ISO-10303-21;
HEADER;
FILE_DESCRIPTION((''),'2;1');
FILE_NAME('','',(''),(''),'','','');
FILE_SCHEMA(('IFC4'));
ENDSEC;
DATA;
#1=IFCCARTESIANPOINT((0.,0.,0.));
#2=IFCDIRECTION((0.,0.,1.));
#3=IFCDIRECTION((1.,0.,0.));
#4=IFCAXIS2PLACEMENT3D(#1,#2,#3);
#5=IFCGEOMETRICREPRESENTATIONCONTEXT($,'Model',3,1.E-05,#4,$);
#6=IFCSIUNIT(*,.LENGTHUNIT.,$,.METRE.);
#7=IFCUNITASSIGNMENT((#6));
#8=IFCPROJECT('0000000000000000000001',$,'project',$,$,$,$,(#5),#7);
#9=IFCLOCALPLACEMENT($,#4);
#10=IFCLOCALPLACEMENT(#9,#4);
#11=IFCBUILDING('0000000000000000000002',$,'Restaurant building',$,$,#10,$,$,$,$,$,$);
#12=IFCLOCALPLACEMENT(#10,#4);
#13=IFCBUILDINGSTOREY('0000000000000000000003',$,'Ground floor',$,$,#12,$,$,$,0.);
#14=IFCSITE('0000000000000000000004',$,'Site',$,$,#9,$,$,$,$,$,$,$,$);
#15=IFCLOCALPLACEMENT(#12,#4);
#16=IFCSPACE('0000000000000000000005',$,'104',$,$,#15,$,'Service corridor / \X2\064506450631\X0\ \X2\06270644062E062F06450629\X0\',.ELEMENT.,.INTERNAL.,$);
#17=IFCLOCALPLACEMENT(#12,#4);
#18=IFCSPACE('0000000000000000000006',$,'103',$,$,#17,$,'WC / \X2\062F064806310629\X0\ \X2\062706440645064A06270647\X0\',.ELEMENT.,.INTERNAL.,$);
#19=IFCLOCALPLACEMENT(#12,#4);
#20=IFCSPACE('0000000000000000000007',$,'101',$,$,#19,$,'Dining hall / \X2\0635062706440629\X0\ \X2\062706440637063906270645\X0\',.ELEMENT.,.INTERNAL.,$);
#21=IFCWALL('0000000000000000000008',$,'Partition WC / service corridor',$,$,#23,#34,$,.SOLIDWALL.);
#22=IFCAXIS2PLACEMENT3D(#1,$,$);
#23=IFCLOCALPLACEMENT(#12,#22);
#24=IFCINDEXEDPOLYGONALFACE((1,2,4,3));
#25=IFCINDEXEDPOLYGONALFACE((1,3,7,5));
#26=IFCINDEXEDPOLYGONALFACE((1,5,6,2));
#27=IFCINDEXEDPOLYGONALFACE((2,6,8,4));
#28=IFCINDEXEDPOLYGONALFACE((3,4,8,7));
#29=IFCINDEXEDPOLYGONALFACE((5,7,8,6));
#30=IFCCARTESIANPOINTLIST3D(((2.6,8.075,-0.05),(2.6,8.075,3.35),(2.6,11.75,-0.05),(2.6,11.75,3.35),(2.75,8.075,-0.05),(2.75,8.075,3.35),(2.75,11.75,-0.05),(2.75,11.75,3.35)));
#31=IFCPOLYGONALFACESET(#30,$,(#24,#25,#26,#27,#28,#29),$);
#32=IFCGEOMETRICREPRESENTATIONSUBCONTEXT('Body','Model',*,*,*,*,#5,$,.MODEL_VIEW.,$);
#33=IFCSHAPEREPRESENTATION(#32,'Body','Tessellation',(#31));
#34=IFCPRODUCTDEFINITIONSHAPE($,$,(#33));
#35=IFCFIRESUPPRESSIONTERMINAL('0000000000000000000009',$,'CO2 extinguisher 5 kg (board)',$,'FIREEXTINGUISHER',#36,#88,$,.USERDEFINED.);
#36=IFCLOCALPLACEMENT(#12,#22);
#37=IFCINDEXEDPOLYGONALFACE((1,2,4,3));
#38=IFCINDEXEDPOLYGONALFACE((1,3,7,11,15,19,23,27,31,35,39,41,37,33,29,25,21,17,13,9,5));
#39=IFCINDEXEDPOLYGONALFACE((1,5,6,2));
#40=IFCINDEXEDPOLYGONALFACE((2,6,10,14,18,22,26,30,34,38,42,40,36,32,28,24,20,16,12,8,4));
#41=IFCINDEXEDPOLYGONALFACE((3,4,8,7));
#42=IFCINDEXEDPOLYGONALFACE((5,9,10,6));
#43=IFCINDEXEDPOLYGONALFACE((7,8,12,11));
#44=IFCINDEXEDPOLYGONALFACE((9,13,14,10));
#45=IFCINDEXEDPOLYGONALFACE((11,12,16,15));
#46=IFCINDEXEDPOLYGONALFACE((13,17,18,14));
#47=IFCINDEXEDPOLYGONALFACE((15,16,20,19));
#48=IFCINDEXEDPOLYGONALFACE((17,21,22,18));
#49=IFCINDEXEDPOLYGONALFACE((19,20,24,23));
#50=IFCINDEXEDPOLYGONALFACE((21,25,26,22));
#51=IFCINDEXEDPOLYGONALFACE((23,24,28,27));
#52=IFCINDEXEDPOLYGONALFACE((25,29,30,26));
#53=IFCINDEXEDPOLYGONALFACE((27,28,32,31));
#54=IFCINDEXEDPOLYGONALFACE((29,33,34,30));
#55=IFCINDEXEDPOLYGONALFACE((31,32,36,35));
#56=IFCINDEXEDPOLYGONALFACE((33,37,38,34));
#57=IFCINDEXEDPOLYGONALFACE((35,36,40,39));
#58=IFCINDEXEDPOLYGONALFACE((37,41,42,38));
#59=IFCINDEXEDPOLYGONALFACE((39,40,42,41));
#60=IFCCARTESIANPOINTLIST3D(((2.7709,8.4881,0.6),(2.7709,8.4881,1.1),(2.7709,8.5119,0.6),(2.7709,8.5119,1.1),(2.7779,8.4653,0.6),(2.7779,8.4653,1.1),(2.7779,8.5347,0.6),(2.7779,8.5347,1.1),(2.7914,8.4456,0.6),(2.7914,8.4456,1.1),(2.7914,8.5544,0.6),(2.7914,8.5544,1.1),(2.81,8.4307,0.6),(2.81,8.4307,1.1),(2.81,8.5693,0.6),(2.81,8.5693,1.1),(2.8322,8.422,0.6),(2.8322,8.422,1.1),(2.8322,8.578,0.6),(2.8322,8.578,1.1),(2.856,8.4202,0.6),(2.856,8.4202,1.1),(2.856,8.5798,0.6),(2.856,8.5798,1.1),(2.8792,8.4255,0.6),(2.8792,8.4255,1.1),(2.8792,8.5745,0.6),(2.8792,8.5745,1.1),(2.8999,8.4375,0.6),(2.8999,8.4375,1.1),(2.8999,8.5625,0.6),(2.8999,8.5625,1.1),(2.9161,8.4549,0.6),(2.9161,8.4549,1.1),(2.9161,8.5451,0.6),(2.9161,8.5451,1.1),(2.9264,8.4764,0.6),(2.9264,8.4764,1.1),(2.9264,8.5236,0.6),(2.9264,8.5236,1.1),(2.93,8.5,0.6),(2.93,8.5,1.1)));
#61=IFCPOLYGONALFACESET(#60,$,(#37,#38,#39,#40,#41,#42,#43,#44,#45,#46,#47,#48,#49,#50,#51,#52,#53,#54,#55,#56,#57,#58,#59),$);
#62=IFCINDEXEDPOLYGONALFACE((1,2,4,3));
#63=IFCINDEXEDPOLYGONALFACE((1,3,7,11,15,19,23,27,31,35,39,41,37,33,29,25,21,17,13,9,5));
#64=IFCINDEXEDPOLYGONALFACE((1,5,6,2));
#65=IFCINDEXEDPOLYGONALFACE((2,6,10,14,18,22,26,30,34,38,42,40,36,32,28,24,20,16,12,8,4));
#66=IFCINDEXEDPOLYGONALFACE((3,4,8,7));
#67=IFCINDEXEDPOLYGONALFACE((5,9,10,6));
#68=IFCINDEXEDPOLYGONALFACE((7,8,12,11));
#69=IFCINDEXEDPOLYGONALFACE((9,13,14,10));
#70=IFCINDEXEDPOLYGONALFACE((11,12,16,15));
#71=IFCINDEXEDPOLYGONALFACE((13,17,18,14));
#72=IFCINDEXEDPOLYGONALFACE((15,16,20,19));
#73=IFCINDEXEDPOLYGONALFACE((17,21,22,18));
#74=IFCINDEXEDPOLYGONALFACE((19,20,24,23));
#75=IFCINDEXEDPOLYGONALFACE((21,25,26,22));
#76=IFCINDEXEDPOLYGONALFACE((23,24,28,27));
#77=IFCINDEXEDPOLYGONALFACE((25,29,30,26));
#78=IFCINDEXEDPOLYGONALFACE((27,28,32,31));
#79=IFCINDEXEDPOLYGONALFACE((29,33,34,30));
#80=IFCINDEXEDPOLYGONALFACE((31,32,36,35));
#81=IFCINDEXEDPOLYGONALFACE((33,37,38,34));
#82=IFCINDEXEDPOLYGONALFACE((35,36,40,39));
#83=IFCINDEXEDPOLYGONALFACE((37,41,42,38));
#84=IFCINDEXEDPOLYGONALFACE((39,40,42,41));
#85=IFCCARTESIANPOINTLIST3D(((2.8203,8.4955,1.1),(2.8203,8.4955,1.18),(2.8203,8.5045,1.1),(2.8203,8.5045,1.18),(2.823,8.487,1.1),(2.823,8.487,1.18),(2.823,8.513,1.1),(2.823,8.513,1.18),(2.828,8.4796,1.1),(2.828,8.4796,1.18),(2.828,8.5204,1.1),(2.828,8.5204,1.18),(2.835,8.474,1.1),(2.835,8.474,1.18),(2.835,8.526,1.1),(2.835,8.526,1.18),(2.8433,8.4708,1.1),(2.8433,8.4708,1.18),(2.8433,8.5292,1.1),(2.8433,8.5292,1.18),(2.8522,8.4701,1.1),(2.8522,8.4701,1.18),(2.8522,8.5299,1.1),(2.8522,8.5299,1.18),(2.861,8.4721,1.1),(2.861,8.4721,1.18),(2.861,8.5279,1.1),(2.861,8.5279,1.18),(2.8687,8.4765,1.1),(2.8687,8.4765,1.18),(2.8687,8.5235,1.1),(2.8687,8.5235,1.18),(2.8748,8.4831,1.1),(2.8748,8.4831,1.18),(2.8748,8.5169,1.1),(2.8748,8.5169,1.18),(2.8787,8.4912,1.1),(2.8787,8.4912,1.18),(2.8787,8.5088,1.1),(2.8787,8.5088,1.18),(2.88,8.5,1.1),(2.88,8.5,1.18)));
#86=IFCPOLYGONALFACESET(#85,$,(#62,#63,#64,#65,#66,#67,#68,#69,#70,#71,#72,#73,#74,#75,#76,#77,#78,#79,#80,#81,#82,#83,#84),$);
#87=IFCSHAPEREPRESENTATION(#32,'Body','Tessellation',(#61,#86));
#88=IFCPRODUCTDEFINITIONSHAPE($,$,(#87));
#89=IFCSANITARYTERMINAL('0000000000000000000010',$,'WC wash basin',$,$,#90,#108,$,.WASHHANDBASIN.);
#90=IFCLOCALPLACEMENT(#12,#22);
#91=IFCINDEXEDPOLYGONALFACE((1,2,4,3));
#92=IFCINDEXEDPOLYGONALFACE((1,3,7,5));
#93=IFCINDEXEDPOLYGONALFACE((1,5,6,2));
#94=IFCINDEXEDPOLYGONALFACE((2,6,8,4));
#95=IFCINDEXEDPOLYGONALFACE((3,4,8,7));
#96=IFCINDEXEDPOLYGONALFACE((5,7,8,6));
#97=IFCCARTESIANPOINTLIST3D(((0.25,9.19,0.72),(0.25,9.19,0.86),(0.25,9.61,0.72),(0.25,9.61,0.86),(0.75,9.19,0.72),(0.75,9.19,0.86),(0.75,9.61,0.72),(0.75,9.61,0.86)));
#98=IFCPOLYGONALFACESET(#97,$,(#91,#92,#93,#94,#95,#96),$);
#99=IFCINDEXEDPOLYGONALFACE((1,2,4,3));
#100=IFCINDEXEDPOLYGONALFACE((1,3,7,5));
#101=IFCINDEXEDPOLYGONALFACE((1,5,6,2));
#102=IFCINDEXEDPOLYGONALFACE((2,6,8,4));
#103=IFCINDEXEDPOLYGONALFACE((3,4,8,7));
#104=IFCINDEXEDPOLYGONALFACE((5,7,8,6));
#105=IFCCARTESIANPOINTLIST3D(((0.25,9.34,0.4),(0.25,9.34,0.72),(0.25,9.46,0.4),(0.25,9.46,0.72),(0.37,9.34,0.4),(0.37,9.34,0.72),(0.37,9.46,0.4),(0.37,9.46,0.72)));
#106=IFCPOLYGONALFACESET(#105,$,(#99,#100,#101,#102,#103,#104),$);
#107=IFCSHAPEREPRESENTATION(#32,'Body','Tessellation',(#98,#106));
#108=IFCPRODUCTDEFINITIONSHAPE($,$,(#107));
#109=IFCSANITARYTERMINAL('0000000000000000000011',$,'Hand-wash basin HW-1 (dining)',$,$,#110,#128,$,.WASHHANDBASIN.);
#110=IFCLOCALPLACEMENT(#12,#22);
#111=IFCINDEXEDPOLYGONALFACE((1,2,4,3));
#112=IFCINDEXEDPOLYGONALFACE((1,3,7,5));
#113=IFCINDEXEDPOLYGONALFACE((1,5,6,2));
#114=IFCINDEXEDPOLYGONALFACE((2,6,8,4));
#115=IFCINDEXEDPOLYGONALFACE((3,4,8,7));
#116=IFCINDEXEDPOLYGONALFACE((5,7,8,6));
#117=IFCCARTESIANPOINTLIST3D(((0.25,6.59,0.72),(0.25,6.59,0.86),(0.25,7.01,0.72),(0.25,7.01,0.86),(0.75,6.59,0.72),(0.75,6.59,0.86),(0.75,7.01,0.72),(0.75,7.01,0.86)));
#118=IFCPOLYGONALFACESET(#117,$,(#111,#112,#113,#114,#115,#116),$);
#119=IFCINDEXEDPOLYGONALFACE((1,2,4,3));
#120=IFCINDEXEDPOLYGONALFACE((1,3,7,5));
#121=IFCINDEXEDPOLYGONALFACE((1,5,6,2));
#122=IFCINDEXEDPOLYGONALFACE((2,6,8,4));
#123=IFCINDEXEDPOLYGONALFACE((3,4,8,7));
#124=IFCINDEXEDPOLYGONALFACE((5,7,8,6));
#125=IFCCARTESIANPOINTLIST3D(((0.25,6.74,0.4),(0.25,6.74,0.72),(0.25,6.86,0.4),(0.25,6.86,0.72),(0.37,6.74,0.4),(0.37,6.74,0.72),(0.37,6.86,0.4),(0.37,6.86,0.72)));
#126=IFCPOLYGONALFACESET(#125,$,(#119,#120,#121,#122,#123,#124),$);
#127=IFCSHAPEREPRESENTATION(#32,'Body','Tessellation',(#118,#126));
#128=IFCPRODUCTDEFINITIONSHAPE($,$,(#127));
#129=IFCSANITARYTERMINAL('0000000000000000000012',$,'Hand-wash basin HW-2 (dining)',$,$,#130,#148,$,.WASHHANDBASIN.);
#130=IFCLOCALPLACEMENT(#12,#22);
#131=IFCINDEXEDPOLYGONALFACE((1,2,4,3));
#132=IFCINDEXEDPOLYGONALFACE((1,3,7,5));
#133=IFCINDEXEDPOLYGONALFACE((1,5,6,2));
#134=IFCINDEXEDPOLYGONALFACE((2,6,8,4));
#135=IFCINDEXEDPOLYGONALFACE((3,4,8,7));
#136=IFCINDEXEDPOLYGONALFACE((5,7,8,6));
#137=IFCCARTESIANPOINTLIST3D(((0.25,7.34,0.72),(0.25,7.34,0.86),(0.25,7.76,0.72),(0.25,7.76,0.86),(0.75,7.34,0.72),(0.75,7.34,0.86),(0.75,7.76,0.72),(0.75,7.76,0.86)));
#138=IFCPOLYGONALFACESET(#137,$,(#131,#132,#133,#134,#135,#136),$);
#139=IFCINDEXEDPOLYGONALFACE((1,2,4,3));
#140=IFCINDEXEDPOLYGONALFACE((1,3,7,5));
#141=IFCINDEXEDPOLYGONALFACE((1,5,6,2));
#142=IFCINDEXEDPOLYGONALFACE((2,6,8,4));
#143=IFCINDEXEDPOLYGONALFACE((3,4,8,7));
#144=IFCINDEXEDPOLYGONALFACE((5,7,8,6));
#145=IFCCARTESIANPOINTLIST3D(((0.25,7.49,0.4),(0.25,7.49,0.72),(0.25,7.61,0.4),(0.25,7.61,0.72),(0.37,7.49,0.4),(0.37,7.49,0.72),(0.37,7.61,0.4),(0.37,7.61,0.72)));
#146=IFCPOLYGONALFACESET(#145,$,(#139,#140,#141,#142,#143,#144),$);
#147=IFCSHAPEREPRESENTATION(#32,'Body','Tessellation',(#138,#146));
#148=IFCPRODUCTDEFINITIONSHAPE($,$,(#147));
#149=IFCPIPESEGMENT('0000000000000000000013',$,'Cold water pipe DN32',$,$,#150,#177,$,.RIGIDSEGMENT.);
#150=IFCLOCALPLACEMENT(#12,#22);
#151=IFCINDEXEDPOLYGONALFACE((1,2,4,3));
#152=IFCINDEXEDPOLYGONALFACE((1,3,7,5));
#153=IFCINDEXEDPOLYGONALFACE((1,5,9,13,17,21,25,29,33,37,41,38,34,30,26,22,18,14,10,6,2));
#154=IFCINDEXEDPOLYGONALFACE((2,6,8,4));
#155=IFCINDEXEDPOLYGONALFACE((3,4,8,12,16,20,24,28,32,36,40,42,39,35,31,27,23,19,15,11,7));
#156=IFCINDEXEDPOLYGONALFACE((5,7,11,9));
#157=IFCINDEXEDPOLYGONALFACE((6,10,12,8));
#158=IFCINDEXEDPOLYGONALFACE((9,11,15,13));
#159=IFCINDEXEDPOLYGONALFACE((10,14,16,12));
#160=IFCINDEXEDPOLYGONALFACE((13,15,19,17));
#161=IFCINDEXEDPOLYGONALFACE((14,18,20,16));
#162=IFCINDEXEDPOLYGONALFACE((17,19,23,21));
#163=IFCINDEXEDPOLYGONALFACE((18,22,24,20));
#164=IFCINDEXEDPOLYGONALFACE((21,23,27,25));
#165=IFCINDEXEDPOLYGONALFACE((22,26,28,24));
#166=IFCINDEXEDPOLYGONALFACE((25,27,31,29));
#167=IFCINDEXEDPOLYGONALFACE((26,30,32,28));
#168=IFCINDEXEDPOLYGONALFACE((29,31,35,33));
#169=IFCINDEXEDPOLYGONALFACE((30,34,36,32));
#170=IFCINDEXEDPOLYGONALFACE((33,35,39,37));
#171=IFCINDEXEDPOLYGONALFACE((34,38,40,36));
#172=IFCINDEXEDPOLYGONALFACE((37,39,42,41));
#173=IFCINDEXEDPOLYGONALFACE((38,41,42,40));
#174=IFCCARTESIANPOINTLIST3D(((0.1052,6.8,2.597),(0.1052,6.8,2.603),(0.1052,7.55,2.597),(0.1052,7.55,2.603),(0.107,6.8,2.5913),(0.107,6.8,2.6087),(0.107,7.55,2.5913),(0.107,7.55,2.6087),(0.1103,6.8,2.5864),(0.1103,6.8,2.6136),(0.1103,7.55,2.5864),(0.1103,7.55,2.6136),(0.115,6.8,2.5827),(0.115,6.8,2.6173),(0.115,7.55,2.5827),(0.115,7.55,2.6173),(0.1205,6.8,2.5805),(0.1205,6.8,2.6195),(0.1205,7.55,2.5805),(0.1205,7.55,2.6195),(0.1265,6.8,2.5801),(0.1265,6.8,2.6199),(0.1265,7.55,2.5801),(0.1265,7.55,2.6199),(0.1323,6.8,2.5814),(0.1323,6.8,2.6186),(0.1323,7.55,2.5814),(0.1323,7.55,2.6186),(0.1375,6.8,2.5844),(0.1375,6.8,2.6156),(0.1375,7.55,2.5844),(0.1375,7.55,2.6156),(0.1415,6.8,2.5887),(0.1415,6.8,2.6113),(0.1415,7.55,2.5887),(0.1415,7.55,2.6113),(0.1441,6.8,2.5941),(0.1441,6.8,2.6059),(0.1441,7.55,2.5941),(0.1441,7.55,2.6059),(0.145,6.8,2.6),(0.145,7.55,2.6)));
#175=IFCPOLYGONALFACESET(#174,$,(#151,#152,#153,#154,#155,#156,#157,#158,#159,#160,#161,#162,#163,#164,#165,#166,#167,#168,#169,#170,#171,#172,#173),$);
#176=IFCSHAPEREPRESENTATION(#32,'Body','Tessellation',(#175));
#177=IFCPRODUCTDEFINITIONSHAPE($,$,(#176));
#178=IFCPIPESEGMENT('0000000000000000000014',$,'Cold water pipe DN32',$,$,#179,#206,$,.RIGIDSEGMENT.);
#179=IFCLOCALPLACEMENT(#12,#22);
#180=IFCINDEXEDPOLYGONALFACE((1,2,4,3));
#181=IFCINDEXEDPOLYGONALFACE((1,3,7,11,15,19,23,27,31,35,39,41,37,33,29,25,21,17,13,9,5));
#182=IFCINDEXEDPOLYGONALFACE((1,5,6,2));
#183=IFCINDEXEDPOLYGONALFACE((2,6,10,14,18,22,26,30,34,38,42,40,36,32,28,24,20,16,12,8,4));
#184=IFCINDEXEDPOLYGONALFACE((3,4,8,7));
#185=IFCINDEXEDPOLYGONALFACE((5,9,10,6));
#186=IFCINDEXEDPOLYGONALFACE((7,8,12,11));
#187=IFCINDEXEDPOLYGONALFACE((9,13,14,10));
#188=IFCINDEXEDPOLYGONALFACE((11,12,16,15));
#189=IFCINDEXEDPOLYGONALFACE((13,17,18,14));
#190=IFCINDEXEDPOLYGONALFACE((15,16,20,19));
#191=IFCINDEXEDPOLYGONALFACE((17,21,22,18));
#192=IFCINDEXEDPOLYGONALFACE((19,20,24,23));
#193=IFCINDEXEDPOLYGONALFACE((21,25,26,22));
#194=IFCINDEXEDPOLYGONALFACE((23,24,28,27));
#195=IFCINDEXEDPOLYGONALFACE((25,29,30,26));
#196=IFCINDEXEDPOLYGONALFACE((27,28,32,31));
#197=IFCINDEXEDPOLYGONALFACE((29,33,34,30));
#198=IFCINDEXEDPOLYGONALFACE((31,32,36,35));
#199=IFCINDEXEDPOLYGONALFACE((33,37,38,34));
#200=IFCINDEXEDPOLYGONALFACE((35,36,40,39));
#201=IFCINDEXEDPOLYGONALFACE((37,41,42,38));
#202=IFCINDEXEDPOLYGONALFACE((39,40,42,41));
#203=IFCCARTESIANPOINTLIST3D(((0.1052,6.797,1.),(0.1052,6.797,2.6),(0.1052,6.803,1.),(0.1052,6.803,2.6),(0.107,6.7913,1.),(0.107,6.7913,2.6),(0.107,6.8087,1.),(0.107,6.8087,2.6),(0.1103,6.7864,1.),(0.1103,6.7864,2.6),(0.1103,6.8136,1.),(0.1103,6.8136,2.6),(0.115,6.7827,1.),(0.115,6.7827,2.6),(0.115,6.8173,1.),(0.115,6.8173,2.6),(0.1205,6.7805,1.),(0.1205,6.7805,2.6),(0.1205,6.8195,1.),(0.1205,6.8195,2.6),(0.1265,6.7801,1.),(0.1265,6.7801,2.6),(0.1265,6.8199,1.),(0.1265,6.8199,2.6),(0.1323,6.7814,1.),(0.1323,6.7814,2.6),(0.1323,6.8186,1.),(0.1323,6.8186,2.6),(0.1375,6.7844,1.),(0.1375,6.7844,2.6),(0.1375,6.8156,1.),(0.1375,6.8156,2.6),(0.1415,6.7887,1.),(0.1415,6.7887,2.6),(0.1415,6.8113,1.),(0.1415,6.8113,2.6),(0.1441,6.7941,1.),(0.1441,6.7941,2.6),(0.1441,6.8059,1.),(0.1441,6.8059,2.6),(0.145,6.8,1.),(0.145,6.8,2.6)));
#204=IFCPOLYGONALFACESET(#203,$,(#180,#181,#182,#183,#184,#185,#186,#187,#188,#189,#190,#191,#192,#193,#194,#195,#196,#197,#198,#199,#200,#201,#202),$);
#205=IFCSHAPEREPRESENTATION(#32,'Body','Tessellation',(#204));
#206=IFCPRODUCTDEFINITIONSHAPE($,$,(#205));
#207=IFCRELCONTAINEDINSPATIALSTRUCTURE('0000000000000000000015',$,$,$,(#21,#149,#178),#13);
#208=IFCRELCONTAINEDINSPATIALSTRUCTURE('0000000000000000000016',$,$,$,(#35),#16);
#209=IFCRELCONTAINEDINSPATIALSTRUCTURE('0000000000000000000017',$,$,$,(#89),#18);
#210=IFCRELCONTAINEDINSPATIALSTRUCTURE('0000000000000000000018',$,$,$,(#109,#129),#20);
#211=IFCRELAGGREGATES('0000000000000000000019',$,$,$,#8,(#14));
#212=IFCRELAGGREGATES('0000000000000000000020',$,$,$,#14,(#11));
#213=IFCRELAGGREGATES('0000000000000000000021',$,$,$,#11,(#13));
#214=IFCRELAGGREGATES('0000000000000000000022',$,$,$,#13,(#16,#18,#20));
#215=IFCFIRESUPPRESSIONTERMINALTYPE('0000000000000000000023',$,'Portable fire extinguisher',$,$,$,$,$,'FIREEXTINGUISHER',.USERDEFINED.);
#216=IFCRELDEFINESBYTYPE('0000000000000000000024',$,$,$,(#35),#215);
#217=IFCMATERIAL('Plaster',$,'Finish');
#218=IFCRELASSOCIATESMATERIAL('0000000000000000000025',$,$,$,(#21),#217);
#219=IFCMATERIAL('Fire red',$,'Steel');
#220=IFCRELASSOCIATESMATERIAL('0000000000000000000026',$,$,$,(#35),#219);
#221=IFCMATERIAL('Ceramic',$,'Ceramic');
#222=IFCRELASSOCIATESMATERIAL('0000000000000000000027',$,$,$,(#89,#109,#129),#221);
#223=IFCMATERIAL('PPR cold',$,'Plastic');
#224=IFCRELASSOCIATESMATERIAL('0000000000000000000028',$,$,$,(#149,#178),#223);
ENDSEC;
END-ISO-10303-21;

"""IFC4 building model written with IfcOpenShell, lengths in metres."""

from ifc_helpers import new_model, si_unit, frame, origin, origin_with_axes, origin_2d, place, context, subcontext, project, spatial, rectangle, circle, extrude, source, transform, mapped, material, type_object, type_shapes, element, save


model = new_model("IFC4")

# Units and contexts
model_context = context("Model", 3, precision=1e-05, world=origin_with_axes())
body_context = subcontext(model_context, "Body", "Model", "MODEL_VIEW")
ifc_project = project(units=[si_unit("LENGTHUNIT", "METRE")], contexts=[model_context])

# Site, building, storey
site_placement = place(None, origin_with_axes())
site = spatial("IfcSite", under=ifc_project, at=site_placement, Name="Site")
building_placement = place(site_placement, origin_with_axes())
building = spatial("IfcBuilding", under=site, at=building_placement, Name="Restaurant building")
storey_placement = place(building_placement, origin_with_axes())
storey = spatial("IfcBuildingStorey", under=building, at=storey_placement, Name="Ground floor", Elevation=0.0)

# Shared definitions
ifc_material_1 = material(Name="Plaster", Category="Finish")

# Wall
wall_1_placement = place(storey_placement, frame((2.675, 8.075, 0.0), z_axis=(0.0, 0.0, 1.0), x_axis=(0.0, 1.0, 0.0)))
element("IfcWall", 1, at=wall_1_placement, inside=storey, material=ifc_material_1, Name="Partition WC / service corridor", PredefinedType="SOLIDWALL", context=body_context, shape_type="SweptSolid", body=[
    extrude(rectangle(XDim=3.675, YDim=0.15, at=origin_2d()), frame((1.8375, 0.0, -0.05)), (0.0, 0.0, 1.0), 3.4),
])

# Shared definitions
space_1_placement = place(storey_placement, origin_with_axes())
space_1 = spatial("IfcSpace", under=storey, at=space_1_placement, Name="104", LongName="Service corridor / ممر الخدمة", CompositionType="ELEMENT", PredefinedType="INTERNAL")

# Fire suppression terminal
ifc_material_2 = material(Name="Fire red", Category="Steel")
fire_suppression_terminal_type = type_object("IfcFireSuppressionTerminalType", Name="Portable fire extinguisher", ElementType="FIREEXTINGUISHER", PredefinedType="USERDEFINED")
shared_shape = source(origin(), body_context, "Body", "SweptSolid", [
    extrude(circle(Radius=0.08, at=origin_2d()), origin(), (0.0, 0.0, 1.0), 0.5),
    extrude(circle(Radius=0.03, at=origin_2d()), frame((0.0, 0.0, 0.5)), (0.0, 0.0, 1.0), 0.08),
])
type_shapes(fire_suppression_terminal_type, [shared_shape])
fire_suppression_terminal_placement = place(storey_placement, frame((2.85, 8.5, 0.6)))
element("IfcFireSuppressionTerminal", 2, at=fire_suppression_terminal_placement, inside=space_1, type_object=fire_suppression_terminal_type, material=ifc_material_2, Name="CO2 extinguisher 5 kg (board)", ObjectType="FIREEXTINGUISHER", PredefinedType="USERDEFINED", context=body_context, shape_type="MappedRepresentation", body=[
    mapped(shared_shape, transform((0.0, 0.0, 0.0))),
])

# Shared definitions
space_2_placement = place(storey_placement, origin_with_axes())
space_2 = spatial("IfcSpace", under=storey, at=space_2_placement, Name="103", LongName="WC / دورة المياه", CompositionType="ELEMENT", PredefinedType="INTERNAL")

# Sanitary terminal
ifc_material_3 = material(Name="Ceramic", Category="Ceramic")
sanitary_terminal_placement = place(storey_placement, frame((0.25, 9.4, 0.0)))
element("IfcSanitaryTerminal", 3, at=sanitary_terminal_placement, inside=space_2, material=ifc_material_3, Name="WC wash basin", PredefinedType="WASHHANDBASIN", context=body_context, shape_type="SweptSolid", body=[
    extrude(rectangle(XDim=0.5, YDim=0.42, at=origin_2d()), frame((0.25, 0.0, 0.72)), (0.0, 0.0, 1.0), 0.14),
    extrude(rectangle(XDim=0.12, YDim=0.12, at=origin_2d()), frame((0.06, 0.0, 0.4)), (0.0, 0.0, 1.0), 0.32),
])

# Shared definitions
space_3_placement = place(storey_placement, origin_with_axes())
space_3 = spatial("IfcSpace", under=storey, at=space_3_placement, Name="101", LongName="Dining hall / صالة الطعام", CompositionType="ELEMENT", PredefinedType="INTERNAL")

# Sanitary terminals
for number, where, name in (
    (4, (0.25, 6.8, 0.0), "Hand-wash basin HW-1 (dining)"),
    (5, (0.25, 7.55, 0.0), "Hand-wash basin HW-2 (dining)"),
):
    element("IfcSanitaryTerminal", number, at=place(storey_placement, frame(where)), inside=space_3, material=ifc_material_3, Name=name, PredefinedType="WASHHANDBASIN", context=body_context, shape_type="SweptSolid", body=[
        extrude(rectangle(XDim=0.5, YDim=0.42, at=origin_2d()), frame((0.25, 0.0, 0.72)), (0.0, 0.0, 1.0), 0.14),
        extrude(rectangle(XDim=0.12, YDim=0.12, at=origin_2d()), frame((0.06, 0.0, 0.4)), (0.0, 0.0, 1.0), 0.32),
    ])

# Pipe segments
ifc_material_4 = material(Name="PPR cold", Category="Plastic")
pipe_segment_1_placement = place(storey_placement, frame((0.125, 7.55, 2.6)))
element("IfcPipeSegment", 6, at=pipe_segment_1_placement, inside=storey, material=ifc_material_4, Name="Cold water pipe DN32", PredefinedType="RIGIDSEGMENT", context=body_context, shape_type="SweptSolid", body=[
    extrude(circle(Radius=0.02, at=origin_2d()), frame((0.0, 0.0, 0.0), z_axis=(0.0, -1.0, 0.0), x_axis=(1.0, 0.0, 0.0)), (0.0, 0.0, 1.0), 0.75),
])
pipe_segment_2_placement = place(storey_placement, frame((0.125, 6.8, 2.6)))
element("IfcPipeSegment", 7, at=pipe_segment_2_placement, inside=storey, material=ifc_material_4, Name="Cold water pipe DN32", PredefinedType="RIGIDSEGMENT", context=body_context, shape_type="SweptSolid", body=[
    extrude(circle(Radius=0.02, at=origin_2d()), frame((0.0, 0.0, 0.0), z_axis=(0.0, 0.0, -1.0), x_axis=(1.0, 0.0, 0.0)), (0.0, 0.0, 1.0), 1.6),
])

save(model, "model.ifc")
